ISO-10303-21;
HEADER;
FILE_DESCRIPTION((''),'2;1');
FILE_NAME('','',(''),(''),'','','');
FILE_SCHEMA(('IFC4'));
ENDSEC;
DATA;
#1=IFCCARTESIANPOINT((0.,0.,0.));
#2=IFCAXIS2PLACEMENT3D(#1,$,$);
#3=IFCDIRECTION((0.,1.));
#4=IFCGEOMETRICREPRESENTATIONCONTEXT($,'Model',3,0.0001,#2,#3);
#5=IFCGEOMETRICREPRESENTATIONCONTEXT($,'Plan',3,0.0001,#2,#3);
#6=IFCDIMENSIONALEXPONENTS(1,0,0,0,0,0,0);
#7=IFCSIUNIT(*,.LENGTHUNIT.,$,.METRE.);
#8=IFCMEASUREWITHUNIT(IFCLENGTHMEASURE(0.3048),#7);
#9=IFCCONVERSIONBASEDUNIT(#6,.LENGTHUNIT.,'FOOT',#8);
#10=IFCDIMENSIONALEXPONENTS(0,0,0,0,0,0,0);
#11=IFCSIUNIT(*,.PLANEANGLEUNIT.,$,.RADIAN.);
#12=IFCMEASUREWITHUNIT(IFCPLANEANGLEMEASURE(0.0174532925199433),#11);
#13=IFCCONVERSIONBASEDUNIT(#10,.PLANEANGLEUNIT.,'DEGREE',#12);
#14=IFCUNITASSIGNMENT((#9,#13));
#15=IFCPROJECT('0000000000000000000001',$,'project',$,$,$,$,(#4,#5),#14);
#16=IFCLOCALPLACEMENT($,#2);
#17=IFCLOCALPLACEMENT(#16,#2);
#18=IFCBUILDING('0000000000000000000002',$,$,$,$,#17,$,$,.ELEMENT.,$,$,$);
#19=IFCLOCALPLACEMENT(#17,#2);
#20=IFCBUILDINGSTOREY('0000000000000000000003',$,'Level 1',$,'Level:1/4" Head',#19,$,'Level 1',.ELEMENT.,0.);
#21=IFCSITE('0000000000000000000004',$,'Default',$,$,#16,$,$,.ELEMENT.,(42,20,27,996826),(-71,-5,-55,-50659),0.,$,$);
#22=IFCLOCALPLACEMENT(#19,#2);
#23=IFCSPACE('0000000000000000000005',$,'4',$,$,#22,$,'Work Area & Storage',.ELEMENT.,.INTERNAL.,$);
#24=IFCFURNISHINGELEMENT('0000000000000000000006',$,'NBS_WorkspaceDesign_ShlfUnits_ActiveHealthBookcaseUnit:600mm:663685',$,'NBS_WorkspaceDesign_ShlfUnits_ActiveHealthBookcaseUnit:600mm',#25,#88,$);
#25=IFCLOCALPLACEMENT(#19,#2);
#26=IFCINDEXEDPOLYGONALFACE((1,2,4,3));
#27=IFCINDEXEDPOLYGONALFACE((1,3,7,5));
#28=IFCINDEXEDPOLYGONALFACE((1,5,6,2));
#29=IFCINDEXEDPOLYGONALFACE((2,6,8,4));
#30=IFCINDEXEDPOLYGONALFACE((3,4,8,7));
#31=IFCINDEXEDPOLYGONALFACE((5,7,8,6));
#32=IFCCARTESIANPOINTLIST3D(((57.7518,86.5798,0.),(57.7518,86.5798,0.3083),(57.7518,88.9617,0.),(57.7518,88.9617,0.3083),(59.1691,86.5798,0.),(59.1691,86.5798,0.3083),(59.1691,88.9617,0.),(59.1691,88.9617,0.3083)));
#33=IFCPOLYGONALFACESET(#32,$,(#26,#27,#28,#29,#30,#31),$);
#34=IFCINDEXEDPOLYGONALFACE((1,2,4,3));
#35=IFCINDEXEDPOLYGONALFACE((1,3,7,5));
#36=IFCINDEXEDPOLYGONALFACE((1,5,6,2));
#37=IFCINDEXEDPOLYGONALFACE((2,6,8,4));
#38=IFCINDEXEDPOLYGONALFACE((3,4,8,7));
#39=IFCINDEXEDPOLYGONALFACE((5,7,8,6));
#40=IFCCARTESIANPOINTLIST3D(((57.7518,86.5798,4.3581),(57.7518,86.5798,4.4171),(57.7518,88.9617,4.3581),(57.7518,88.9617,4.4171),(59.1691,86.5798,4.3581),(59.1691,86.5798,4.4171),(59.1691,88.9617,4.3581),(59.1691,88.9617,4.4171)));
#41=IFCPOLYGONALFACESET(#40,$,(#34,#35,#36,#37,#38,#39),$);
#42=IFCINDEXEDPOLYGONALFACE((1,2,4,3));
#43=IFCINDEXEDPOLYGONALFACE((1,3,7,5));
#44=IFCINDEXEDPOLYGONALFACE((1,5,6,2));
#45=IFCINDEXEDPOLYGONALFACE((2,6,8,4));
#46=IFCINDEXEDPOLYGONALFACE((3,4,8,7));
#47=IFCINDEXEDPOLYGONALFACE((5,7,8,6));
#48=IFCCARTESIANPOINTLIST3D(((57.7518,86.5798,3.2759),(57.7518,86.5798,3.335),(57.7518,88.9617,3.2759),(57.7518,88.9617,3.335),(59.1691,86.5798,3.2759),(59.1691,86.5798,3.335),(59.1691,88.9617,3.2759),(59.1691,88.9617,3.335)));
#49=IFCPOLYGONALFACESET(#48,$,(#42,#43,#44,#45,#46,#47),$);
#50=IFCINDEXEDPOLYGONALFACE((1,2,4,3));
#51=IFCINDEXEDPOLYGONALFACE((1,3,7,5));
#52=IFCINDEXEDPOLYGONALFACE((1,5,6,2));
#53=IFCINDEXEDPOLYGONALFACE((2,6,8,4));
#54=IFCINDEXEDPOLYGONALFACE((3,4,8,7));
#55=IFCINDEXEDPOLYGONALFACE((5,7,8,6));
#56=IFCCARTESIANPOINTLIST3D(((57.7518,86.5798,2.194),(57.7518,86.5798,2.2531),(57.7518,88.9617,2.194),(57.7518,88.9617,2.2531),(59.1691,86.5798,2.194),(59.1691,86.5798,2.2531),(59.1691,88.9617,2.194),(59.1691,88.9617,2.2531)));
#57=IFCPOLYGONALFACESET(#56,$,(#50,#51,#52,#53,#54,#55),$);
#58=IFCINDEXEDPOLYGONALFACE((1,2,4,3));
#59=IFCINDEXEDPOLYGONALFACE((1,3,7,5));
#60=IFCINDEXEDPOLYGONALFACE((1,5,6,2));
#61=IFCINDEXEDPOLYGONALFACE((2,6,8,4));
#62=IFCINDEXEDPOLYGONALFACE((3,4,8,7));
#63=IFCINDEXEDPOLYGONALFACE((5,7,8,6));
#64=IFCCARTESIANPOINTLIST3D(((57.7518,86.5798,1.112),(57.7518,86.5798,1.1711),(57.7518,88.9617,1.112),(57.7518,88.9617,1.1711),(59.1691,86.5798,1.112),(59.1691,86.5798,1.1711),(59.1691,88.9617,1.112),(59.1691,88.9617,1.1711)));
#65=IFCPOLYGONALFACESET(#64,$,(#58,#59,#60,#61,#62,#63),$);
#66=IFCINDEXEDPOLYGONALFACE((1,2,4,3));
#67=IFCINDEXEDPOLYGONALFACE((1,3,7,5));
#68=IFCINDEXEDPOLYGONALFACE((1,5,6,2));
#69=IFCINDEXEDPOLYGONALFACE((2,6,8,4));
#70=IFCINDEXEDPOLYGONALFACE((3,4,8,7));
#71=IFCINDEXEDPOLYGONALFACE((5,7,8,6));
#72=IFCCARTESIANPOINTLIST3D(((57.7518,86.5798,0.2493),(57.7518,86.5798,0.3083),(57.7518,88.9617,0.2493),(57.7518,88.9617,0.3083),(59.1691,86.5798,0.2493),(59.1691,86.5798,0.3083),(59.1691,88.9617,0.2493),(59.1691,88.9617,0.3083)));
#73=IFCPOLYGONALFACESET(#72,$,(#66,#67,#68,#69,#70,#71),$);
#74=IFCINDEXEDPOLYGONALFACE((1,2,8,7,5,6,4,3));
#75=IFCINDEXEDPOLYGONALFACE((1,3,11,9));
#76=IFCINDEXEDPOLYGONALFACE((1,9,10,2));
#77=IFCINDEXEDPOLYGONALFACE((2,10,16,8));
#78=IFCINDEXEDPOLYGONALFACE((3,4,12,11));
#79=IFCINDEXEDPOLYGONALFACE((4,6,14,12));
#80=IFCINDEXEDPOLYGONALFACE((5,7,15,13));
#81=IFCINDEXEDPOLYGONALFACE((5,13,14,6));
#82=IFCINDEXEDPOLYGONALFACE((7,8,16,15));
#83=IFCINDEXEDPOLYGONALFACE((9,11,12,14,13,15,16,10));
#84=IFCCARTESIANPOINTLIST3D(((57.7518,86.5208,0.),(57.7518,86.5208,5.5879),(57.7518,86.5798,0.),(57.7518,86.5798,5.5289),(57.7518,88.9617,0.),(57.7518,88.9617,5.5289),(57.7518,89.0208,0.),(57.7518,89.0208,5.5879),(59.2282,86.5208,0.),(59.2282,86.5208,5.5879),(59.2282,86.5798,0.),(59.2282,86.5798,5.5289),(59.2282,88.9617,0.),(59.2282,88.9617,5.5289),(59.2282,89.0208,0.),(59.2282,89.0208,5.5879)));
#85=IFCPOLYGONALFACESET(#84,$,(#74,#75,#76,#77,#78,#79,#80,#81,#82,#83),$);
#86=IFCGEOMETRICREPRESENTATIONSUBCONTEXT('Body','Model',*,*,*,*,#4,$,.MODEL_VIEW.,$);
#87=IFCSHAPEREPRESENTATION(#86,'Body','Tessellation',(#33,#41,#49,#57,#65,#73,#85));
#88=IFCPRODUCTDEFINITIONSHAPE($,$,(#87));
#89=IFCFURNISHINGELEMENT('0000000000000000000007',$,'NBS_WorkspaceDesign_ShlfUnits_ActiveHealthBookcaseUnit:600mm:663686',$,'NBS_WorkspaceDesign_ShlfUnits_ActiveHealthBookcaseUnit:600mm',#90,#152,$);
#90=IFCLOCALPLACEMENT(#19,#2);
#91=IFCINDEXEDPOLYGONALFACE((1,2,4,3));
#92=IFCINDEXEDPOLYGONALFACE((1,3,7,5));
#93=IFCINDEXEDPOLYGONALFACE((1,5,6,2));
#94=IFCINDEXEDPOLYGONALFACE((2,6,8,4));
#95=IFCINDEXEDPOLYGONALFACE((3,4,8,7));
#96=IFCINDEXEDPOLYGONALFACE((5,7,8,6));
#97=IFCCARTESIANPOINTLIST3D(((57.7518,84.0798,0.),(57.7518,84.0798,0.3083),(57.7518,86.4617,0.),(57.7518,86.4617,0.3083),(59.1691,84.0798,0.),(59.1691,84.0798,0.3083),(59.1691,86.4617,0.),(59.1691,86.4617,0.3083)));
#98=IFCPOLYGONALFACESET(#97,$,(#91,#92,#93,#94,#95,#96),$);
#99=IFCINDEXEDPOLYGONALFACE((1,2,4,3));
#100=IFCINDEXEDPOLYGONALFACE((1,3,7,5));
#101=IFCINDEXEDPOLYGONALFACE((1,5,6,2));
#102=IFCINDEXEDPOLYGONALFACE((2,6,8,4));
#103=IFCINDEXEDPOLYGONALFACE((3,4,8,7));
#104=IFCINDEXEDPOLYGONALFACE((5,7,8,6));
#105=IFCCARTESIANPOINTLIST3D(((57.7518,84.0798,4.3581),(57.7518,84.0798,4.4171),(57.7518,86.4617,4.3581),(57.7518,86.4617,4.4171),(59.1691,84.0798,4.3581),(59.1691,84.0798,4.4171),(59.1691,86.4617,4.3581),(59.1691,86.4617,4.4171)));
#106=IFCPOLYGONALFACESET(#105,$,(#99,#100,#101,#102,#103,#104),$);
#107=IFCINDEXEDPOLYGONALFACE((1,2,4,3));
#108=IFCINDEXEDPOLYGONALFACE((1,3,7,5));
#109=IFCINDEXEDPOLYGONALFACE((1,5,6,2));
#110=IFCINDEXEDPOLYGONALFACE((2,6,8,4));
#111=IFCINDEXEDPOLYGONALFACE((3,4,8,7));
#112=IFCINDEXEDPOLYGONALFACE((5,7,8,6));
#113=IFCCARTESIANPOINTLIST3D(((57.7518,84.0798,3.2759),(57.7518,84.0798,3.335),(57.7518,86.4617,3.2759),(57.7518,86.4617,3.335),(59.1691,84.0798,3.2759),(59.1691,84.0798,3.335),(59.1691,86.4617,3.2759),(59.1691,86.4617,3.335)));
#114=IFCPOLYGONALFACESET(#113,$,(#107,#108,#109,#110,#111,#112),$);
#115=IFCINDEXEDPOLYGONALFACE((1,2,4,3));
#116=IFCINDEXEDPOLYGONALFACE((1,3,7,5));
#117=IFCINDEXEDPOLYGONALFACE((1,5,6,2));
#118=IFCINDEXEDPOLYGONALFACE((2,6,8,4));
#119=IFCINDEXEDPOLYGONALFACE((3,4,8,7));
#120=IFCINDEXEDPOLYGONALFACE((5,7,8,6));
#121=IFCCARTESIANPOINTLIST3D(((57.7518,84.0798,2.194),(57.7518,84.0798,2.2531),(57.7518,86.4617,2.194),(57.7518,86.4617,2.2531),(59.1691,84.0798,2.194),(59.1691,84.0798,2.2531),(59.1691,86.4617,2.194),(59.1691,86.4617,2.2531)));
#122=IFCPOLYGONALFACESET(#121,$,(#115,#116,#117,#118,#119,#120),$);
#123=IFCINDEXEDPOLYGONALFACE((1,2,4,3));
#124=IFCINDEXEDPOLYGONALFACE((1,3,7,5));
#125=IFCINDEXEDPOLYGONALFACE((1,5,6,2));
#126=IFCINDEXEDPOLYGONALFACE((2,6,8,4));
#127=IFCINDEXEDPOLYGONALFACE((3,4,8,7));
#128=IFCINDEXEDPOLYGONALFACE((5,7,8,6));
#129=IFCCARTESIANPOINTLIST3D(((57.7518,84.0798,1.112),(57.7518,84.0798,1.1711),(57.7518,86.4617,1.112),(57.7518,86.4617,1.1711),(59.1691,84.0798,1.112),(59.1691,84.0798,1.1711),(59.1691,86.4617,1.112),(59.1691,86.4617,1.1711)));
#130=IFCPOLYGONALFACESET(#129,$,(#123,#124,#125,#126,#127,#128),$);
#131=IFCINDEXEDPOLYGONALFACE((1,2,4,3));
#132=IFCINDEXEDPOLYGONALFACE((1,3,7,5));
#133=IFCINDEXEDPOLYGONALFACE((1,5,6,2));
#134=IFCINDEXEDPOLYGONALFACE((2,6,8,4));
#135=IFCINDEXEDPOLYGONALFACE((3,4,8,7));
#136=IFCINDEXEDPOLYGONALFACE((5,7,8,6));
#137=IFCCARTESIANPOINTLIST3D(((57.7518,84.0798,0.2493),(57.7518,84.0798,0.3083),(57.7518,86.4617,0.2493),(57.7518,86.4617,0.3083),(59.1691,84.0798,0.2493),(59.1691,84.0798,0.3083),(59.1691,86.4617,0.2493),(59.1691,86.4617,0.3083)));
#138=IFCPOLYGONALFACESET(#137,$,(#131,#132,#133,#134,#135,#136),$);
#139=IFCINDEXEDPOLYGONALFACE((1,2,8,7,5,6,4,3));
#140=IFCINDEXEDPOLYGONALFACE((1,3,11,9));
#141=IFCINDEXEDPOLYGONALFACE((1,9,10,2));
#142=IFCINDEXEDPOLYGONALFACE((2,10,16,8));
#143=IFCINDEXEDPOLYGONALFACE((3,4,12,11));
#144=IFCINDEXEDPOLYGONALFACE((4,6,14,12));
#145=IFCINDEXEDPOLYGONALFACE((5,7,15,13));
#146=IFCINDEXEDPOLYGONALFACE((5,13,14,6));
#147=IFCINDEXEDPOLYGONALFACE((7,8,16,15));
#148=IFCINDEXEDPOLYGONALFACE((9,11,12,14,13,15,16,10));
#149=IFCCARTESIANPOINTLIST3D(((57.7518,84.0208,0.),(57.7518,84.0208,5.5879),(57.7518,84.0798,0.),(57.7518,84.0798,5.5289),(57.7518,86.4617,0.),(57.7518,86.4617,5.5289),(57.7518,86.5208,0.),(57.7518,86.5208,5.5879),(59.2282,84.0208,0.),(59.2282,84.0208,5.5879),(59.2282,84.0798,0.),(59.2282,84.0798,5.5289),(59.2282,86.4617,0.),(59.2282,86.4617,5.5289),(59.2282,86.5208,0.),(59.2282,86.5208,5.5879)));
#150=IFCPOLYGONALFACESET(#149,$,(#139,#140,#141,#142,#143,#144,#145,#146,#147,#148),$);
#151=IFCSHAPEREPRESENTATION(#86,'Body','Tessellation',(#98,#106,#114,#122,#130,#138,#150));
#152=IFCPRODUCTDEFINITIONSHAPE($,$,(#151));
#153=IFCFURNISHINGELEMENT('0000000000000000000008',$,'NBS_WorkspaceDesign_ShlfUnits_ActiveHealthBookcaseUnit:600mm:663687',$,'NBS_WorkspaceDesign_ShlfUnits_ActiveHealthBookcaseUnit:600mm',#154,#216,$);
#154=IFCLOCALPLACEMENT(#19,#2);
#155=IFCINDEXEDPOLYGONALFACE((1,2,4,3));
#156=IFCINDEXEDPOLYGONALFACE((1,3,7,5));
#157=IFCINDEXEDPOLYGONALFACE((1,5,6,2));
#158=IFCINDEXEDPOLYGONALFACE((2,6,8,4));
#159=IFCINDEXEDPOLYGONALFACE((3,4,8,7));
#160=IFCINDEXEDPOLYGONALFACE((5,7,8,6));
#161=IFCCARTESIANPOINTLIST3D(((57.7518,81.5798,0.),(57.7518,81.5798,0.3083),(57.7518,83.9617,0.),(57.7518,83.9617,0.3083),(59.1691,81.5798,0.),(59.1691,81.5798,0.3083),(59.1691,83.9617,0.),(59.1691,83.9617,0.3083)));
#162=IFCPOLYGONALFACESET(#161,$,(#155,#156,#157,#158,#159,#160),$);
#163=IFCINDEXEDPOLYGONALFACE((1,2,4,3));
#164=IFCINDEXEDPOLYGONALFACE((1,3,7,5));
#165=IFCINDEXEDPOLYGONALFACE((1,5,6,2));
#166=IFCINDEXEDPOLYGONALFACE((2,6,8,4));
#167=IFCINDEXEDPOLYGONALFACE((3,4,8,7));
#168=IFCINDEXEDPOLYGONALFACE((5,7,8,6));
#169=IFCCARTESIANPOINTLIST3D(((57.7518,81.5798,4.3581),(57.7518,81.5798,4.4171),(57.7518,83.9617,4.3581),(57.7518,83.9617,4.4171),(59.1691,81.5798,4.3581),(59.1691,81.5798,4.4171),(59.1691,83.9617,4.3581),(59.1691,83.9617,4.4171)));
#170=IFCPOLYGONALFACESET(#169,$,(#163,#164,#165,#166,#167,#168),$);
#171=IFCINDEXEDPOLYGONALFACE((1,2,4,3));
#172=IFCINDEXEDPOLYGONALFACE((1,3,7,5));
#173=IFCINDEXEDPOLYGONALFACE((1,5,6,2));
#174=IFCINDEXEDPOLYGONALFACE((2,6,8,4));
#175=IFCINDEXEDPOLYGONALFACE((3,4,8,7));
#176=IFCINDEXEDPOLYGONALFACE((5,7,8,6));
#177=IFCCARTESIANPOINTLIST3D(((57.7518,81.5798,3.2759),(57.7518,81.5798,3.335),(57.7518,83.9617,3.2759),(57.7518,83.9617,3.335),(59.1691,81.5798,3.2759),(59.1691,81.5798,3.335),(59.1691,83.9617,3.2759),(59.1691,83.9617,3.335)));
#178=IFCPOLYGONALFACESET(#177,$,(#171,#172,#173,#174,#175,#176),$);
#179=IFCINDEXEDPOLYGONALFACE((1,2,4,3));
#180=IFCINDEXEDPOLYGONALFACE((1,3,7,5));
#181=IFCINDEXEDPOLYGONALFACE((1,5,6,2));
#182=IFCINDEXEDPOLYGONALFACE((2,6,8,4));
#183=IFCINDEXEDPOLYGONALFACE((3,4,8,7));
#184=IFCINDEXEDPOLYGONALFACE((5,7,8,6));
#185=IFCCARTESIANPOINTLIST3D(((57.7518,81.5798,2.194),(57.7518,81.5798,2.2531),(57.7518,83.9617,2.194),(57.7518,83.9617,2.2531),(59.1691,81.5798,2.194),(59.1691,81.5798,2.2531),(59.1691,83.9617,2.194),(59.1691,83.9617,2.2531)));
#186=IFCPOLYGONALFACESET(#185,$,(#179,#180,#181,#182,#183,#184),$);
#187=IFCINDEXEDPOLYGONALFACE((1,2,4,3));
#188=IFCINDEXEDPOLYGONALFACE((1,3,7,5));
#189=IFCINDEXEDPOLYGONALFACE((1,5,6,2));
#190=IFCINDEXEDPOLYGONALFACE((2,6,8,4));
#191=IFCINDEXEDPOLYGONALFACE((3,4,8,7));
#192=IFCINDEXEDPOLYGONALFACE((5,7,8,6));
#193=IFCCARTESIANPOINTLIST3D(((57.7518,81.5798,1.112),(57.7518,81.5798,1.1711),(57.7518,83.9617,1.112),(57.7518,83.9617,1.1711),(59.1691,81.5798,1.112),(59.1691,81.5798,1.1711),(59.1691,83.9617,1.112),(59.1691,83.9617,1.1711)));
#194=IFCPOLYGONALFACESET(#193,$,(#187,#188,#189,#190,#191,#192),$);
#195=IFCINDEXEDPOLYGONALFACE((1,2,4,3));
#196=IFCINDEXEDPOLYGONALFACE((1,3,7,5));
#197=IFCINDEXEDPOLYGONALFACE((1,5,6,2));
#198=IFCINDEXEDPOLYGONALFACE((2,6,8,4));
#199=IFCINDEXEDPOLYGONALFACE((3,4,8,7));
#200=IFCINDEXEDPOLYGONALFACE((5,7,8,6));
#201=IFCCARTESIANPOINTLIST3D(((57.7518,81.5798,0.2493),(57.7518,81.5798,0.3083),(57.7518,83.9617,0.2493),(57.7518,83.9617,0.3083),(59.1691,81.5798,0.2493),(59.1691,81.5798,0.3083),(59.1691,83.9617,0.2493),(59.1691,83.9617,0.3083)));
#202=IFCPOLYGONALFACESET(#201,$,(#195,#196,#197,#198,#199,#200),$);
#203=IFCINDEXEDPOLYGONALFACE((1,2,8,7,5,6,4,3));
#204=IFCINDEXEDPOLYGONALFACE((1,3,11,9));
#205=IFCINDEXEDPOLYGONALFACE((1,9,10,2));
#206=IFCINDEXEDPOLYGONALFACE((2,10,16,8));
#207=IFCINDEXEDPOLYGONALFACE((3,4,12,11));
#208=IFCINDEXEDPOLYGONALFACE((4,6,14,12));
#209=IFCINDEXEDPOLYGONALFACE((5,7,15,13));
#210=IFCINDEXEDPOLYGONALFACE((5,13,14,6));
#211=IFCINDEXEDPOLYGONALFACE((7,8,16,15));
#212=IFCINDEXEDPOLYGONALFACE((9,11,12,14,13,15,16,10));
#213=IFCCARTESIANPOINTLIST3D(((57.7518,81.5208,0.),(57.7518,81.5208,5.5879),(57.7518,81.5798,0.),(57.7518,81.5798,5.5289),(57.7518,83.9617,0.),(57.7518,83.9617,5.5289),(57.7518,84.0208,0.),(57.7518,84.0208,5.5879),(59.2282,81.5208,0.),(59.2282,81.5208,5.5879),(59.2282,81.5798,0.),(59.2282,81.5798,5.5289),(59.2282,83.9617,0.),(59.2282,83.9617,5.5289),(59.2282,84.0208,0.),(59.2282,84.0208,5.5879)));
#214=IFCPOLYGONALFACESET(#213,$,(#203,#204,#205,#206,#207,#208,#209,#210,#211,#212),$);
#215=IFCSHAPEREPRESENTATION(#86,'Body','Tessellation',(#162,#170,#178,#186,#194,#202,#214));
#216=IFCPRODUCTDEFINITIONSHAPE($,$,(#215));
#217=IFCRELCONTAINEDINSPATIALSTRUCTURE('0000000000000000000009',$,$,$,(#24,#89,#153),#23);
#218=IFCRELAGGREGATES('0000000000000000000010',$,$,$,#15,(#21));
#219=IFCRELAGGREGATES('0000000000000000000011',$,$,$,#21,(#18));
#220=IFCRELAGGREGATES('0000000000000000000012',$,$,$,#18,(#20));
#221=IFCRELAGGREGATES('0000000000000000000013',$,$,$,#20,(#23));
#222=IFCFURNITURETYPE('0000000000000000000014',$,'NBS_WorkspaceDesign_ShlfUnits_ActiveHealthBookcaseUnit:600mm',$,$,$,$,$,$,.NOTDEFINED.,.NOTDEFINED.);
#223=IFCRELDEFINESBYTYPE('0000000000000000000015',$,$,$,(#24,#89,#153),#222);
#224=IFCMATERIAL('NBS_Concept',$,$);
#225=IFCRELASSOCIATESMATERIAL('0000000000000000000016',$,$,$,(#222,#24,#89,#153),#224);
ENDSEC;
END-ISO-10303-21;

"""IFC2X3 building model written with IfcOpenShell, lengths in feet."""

from ifc_helpers import new_model, entity, si_unit, converted_unit, direction, frame, frame_2d, origin, place, context, subcontext, project, spatial, polyline, rectangle, outline, extrude, source, transform, mapped, material, type_object, type_shapes, element, save


model = new_model("IFC2X3")

# Units and contexts
model_context = context("Model", 3, precision=0.0001, world=origin(), true_north=direction((0.0, 1.0)))
plan_context = context("Plan", 3, precision=0.0001, world=origin(), true_north=direction((0.0, 1.0)))
body_context = subcontext(model_context, "Body", "Model", "MODEL_VIEW")
ifc_project = project(units=[converted_unit("LENGTHUNIT", "FOOT", entity("IfcLengthMeasure", 0.3048), si_unit("LENGTHUNIT", "METRE"), dimensions=[1, 0, 0, 0, 0, 0, 0]), converted_unit("PLANEANGLEUNIT", "DEGREE", entity("IfcPlaneAngleMeasure", 0.0174532925199433), si_unit("PLANEANGLEUNIT", "RADIAN"), dimensions=[0, 0, 0, 0, 0, 0, 0])], contexts=[model_context, plan_context])

# Site, building, storey
site_placement = place(None, origin())
site = spatial("IfcSite", under=ifc_project, at=site_placement, Name="Default", CompositionType="ELEMENT", RefLatitude=(42, 20, 27, 996826), RefLongitude=(-71, -5, -55, -50659), RefElevation=0.0)
building_placement = place(site_placement, origin())
building = spatial("IfcBuilding", under=site, at=building_placement, CompositionType="ELEMENT")
storey_placement = place(building_placement, origin())
storey = spatial("IfcBuildingStorey", under=building, at=storey_placement, Name="Level 1", ObjectType="Level:1/4\" Head", LongName="Level 1", CompositionType="ELEMENT", Elevation=0.0)

# Shared definitions
space_1_placement = place(storey_placement, origin())
space_1 = spatial("IfcSpace", under=storey, at=space_1_placement, Name="4", LongName="Work Area & Storage", CompositionType="ELEMENT", InteriorOrExteriorSpace="INTERNAL")

# Furnishing elements
ifc_material_1 = material(Name="NBS_Concept")
furniture_type_1 = type_object("IfcFurnitureType", Name="NBS_WorkspaceDesign_ShlfUnits_ActiveHealthBookcaseUnit:600mm", AssemblyPlace="NOTDEFINED", material=ifc_material_1)
shared_shape_1 = source(origin(), body_context, "Body", "SweptSolid", [
    extrude(rectangle(XDim=1.4173, YDim=2.3819, at=frame_2d((0.0, 0.0), x_axis=(1.0, 0.0))), frame((0.0, -0.7677, 0.0), z_axis=(0.0, 0.0, 1.0), x_axis=(0.0, 1.0, 0.0)), (0.0, 0.0, 1.0), 0.3083),
    extrude(rectangle(XDim=1.4173, YDim=2.3819, at=frame_2d((0.0, 0.0), x_axis=(1.0, 0.0))), frame((0.0, -0.7677, 4.3581), z_axis=(0.0, 0.0, 1.0), x_axis=(0.0, 1.0, 0.0)), (0.0, 0.0, 1.0), 0.0591),
    extrude(rectangle(XDim=1.4173, YDim=2.3819, at=frame_2d((0.0, 0.0), x_axis=(1.0, 0.0))), frame((0.0, -0.7677, 3.2759), z_axis=(0.0, 0.0, 1.0), x_axis=(0.0, 1.0, 0.0)), (0.0, 0.0, 1.0), 0.0591),
    extrude(rectangle(XDim=1.4173, YDim=2.3819, at=frame_2d((0.0, 0.0), x_axis=(1.0, 0.0))), frame((0.0, -0.7677, 2.194), z_axis=(0.0, 0.0, 1.0), x_axis=(0.0, 1.0, 0.0)), (0.0, 0.0, 1.0), 0.0591),
    extrude(rectangle(XDim=1.4173, YDim=2.3819, at=frame_2d((0.0, 0.0), x_axis=(1.0, 0.0))), frame((0.0, -0.7677, 1.112), z_axis=(0.0, 0.0, 1.0), x_axis=(0.0, 1.0, 0.0)), (0.0, 0.0, 1.0), 0.0591),
    extrude(rectangle(XDim=1.4173, YDim=2.3819, at=frame_2d((0.0, 0.0), x_axis=(1.0, 0.0))), frame((0.0, -0.7677, 0.2493), z_axis=(0.0, 0.0, 1.0), x_axis=(0.0, 1.0, 0.0)), (0.0, 0.0, 1.0), 0.0591),
    extrude(outline(polyline([(-2.8087, -1.25), (2.7792, -1.25), (2.7792, -1.1909), (-2.7497, -1.1909), (-2.7497, 1.1909), (2.7792, 1.1909), (2.7792, 1.25), (-2.8087, 1.25), (-2.8087, -1.25)])), frame((0.0, -1.4764, 2.7792), z_axis=(0.0, 1.0, 0.0), x_axis=(0.0, 0.0, -1.0)), (0.0, 0.0, 1.0), 1.4764),
])
type_shapes(furniture_type_1, [shared_shape_1])
for number, where, z_axis, x_axis, name in (
    (1, (59.2282, 87.7708, 0.0), (0.0, 0.0, 1.0), (0.0, -1.0, 0.0), "NBS_WorkspaceDesign_ShlfUnits_ActiveHealthBookcaseUnit:600mm:663685"),
    (2, (59.2282, 85.2708, 0.0), (0.0, 0.0, 1.0), (0.0, -1.0, 0.0), "NBS_WorkspaceDesign_ShlfUnits_ActiveHealthBookcaseUnit:600mm:663686"),
    (3, (59.2282, 82.7708, 0.0), (0.0, 0.0, 1.0), (0.0, -1.0, 0.0), "NBS_WorkspaceDesign_ShlfUnits_ActiveHealthBookcaseUnit:600mm:663687"),
):
    element("IfcFurnishingElement", number, at=place(space_1_placement, frame(where, z_axis=z_axis, x_axis=x_axis)), inside=space_1, type_object=furniture_type_1, material=ifc_material_1, Name=name, ObjectType="NBS_WorkspaceDesign_ShlfUnits_ActiveHealthBookcaseUnit:600mm", context=body_context, shape_type="MappedRepresentation", body=[
        mapped(shared_shape_1, transform((0.0, 0.0, 0.0), scale=1.0)),
    ])

save(model, "model.ifc")
